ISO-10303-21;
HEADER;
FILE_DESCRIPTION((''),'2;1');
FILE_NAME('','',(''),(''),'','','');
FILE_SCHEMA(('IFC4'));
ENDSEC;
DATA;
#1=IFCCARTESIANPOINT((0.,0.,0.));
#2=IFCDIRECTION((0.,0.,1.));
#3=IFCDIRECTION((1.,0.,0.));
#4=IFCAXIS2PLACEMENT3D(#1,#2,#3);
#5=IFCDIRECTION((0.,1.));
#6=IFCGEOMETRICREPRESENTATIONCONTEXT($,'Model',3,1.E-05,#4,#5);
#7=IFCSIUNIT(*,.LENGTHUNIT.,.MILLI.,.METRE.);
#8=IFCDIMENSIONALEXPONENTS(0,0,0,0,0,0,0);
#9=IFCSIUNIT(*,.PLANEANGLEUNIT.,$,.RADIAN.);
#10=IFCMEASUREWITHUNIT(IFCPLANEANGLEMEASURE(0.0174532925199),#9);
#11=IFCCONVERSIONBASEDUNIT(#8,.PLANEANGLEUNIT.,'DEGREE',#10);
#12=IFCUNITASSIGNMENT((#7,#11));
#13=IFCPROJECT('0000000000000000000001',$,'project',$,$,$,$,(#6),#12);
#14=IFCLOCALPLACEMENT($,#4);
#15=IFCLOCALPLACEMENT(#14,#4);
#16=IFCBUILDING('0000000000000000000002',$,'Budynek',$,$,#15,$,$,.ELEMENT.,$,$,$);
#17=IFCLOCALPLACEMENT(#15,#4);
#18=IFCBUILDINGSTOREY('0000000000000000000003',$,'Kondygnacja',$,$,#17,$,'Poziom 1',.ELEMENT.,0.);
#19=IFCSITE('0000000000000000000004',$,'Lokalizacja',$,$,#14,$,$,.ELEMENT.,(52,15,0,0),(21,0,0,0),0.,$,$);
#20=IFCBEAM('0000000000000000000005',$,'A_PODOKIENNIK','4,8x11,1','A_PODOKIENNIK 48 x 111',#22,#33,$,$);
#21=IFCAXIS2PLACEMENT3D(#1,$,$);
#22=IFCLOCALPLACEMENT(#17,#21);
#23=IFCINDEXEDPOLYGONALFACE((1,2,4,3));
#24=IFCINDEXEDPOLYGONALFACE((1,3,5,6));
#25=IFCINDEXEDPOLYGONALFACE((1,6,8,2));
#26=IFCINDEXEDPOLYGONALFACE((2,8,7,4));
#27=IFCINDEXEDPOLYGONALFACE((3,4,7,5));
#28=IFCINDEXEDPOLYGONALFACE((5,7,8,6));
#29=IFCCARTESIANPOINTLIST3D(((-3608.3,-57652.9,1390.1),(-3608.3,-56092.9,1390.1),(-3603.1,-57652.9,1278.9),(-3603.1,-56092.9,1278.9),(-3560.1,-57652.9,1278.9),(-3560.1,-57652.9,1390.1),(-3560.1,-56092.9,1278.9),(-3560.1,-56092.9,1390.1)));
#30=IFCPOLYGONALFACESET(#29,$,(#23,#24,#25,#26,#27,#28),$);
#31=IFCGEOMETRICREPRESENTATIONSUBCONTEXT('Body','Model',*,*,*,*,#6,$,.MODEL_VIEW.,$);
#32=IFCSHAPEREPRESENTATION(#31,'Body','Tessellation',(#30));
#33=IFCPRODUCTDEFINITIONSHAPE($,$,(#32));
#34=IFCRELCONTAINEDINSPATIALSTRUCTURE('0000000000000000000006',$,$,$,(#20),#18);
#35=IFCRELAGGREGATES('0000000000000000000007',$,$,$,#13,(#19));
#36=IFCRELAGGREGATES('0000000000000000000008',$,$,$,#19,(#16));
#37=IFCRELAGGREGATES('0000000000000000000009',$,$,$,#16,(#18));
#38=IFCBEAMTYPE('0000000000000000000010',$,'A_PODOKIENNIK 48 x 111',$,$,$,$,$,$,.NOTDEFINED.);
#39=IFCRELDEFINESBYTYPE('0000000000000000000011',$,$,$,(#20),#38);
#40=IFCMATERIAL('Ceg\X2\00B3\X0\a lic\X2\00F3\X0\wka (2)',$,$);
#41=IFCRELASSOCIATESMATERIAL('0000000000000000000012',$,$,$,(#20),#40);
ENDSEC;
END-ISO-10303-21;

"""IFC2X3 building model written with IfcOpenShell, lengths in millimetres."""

from ifc_helpers import new_model, entity, si_unit, converted_unit, direction, frame, origin_with_axes, place, context, subcontext, project, spatial, polyline, outline, extrude, material, type_object, element, save


model = new_model("IFC2X3")

# Units and contexts
model_context = context("Model", 3, precision=1e-05, world=origin_with_axes(), true_north=direction((0.0, 1.0)))
body_context = subcontext(model_context, "Body", "Model", "MODEL_VIEW")
ifc_project = project(units=[si_unit("LENGTHUNIT", "METRE", prefix="MILLI"), converted_unit("PLANEANGLEUNIT", "DEGREE", entity("IfcPlaneAngleMeasure", 0.0174532925199), si_unit("PLANEANGLEUNIT", "RADIAN"), dimensions=[0, 0, 0, 0, 0, 0, 0])], contexts=[model_context])

# Site, building, storey
site_placement = place(None, origin_with_axes())
site = spatial("IfcSite", under=ifc_project, at=site_placement, Name="Lokalizacja", CompositionType="ELEMENT", RefLatitude=(52, 15, 0, 0), RefLongitude=(21, 0, 0, 0), RefElevation=0.0)
building_placement = place(site_placement, origin_with_axes())
building = spatial("IfcBuilding", under=site, at=building_placement, Name="Budynek", CompositionType="ELEMENT")
storey_placement = place(building_placement, origin_with_axes())
storey = spatial("IfcBuildingStorey", under=building, at=storey_placement, Name="Kondygnacja", LongName="Poziom 1", CompositionType="ELEMENT", Elevation=0.0)

# Beam
ifc_material_1 = material(Name="Ceg³a licówka (2)")
beam_type_1 = type_object("IfcBeamType", Name="A_PODOKIENNIK 48 x 111", PredefinedType="NOTDEFINED")
beam_1_placement = place(storey_placement, frame((-3560.1, -56092.9, 1278.9), z_axis=(0.0, 0.0, 1.0), x_axis=(-1.0, 0.0, 0.0)))
element("IfcBeam", 1, at=beam_1_placement, inside=storey, type_object=beam_type_1, material=ifc_material_1, Name="A_PODOKIENNIK", Description="4,8x11,1", ObjectType="A_PODOKIENNIK 48 x 111", context=body_context, shape_type="SweptSolid", body=[
    extrude(outline(polyline([(0.0, 0.0), (43.0, 0.0), (48.2, 111.1), (0.0, 111.1), (0.0, 0.0)])), frame((0.0, 1560.0, 0.0), z_axis=(0.0, -1.0, 0.0), x_axis=(1.0, 0.0, 0.0)), (0.0, 0.0, 1.0), 1560.0),
])

save(model, "model.ifc")
